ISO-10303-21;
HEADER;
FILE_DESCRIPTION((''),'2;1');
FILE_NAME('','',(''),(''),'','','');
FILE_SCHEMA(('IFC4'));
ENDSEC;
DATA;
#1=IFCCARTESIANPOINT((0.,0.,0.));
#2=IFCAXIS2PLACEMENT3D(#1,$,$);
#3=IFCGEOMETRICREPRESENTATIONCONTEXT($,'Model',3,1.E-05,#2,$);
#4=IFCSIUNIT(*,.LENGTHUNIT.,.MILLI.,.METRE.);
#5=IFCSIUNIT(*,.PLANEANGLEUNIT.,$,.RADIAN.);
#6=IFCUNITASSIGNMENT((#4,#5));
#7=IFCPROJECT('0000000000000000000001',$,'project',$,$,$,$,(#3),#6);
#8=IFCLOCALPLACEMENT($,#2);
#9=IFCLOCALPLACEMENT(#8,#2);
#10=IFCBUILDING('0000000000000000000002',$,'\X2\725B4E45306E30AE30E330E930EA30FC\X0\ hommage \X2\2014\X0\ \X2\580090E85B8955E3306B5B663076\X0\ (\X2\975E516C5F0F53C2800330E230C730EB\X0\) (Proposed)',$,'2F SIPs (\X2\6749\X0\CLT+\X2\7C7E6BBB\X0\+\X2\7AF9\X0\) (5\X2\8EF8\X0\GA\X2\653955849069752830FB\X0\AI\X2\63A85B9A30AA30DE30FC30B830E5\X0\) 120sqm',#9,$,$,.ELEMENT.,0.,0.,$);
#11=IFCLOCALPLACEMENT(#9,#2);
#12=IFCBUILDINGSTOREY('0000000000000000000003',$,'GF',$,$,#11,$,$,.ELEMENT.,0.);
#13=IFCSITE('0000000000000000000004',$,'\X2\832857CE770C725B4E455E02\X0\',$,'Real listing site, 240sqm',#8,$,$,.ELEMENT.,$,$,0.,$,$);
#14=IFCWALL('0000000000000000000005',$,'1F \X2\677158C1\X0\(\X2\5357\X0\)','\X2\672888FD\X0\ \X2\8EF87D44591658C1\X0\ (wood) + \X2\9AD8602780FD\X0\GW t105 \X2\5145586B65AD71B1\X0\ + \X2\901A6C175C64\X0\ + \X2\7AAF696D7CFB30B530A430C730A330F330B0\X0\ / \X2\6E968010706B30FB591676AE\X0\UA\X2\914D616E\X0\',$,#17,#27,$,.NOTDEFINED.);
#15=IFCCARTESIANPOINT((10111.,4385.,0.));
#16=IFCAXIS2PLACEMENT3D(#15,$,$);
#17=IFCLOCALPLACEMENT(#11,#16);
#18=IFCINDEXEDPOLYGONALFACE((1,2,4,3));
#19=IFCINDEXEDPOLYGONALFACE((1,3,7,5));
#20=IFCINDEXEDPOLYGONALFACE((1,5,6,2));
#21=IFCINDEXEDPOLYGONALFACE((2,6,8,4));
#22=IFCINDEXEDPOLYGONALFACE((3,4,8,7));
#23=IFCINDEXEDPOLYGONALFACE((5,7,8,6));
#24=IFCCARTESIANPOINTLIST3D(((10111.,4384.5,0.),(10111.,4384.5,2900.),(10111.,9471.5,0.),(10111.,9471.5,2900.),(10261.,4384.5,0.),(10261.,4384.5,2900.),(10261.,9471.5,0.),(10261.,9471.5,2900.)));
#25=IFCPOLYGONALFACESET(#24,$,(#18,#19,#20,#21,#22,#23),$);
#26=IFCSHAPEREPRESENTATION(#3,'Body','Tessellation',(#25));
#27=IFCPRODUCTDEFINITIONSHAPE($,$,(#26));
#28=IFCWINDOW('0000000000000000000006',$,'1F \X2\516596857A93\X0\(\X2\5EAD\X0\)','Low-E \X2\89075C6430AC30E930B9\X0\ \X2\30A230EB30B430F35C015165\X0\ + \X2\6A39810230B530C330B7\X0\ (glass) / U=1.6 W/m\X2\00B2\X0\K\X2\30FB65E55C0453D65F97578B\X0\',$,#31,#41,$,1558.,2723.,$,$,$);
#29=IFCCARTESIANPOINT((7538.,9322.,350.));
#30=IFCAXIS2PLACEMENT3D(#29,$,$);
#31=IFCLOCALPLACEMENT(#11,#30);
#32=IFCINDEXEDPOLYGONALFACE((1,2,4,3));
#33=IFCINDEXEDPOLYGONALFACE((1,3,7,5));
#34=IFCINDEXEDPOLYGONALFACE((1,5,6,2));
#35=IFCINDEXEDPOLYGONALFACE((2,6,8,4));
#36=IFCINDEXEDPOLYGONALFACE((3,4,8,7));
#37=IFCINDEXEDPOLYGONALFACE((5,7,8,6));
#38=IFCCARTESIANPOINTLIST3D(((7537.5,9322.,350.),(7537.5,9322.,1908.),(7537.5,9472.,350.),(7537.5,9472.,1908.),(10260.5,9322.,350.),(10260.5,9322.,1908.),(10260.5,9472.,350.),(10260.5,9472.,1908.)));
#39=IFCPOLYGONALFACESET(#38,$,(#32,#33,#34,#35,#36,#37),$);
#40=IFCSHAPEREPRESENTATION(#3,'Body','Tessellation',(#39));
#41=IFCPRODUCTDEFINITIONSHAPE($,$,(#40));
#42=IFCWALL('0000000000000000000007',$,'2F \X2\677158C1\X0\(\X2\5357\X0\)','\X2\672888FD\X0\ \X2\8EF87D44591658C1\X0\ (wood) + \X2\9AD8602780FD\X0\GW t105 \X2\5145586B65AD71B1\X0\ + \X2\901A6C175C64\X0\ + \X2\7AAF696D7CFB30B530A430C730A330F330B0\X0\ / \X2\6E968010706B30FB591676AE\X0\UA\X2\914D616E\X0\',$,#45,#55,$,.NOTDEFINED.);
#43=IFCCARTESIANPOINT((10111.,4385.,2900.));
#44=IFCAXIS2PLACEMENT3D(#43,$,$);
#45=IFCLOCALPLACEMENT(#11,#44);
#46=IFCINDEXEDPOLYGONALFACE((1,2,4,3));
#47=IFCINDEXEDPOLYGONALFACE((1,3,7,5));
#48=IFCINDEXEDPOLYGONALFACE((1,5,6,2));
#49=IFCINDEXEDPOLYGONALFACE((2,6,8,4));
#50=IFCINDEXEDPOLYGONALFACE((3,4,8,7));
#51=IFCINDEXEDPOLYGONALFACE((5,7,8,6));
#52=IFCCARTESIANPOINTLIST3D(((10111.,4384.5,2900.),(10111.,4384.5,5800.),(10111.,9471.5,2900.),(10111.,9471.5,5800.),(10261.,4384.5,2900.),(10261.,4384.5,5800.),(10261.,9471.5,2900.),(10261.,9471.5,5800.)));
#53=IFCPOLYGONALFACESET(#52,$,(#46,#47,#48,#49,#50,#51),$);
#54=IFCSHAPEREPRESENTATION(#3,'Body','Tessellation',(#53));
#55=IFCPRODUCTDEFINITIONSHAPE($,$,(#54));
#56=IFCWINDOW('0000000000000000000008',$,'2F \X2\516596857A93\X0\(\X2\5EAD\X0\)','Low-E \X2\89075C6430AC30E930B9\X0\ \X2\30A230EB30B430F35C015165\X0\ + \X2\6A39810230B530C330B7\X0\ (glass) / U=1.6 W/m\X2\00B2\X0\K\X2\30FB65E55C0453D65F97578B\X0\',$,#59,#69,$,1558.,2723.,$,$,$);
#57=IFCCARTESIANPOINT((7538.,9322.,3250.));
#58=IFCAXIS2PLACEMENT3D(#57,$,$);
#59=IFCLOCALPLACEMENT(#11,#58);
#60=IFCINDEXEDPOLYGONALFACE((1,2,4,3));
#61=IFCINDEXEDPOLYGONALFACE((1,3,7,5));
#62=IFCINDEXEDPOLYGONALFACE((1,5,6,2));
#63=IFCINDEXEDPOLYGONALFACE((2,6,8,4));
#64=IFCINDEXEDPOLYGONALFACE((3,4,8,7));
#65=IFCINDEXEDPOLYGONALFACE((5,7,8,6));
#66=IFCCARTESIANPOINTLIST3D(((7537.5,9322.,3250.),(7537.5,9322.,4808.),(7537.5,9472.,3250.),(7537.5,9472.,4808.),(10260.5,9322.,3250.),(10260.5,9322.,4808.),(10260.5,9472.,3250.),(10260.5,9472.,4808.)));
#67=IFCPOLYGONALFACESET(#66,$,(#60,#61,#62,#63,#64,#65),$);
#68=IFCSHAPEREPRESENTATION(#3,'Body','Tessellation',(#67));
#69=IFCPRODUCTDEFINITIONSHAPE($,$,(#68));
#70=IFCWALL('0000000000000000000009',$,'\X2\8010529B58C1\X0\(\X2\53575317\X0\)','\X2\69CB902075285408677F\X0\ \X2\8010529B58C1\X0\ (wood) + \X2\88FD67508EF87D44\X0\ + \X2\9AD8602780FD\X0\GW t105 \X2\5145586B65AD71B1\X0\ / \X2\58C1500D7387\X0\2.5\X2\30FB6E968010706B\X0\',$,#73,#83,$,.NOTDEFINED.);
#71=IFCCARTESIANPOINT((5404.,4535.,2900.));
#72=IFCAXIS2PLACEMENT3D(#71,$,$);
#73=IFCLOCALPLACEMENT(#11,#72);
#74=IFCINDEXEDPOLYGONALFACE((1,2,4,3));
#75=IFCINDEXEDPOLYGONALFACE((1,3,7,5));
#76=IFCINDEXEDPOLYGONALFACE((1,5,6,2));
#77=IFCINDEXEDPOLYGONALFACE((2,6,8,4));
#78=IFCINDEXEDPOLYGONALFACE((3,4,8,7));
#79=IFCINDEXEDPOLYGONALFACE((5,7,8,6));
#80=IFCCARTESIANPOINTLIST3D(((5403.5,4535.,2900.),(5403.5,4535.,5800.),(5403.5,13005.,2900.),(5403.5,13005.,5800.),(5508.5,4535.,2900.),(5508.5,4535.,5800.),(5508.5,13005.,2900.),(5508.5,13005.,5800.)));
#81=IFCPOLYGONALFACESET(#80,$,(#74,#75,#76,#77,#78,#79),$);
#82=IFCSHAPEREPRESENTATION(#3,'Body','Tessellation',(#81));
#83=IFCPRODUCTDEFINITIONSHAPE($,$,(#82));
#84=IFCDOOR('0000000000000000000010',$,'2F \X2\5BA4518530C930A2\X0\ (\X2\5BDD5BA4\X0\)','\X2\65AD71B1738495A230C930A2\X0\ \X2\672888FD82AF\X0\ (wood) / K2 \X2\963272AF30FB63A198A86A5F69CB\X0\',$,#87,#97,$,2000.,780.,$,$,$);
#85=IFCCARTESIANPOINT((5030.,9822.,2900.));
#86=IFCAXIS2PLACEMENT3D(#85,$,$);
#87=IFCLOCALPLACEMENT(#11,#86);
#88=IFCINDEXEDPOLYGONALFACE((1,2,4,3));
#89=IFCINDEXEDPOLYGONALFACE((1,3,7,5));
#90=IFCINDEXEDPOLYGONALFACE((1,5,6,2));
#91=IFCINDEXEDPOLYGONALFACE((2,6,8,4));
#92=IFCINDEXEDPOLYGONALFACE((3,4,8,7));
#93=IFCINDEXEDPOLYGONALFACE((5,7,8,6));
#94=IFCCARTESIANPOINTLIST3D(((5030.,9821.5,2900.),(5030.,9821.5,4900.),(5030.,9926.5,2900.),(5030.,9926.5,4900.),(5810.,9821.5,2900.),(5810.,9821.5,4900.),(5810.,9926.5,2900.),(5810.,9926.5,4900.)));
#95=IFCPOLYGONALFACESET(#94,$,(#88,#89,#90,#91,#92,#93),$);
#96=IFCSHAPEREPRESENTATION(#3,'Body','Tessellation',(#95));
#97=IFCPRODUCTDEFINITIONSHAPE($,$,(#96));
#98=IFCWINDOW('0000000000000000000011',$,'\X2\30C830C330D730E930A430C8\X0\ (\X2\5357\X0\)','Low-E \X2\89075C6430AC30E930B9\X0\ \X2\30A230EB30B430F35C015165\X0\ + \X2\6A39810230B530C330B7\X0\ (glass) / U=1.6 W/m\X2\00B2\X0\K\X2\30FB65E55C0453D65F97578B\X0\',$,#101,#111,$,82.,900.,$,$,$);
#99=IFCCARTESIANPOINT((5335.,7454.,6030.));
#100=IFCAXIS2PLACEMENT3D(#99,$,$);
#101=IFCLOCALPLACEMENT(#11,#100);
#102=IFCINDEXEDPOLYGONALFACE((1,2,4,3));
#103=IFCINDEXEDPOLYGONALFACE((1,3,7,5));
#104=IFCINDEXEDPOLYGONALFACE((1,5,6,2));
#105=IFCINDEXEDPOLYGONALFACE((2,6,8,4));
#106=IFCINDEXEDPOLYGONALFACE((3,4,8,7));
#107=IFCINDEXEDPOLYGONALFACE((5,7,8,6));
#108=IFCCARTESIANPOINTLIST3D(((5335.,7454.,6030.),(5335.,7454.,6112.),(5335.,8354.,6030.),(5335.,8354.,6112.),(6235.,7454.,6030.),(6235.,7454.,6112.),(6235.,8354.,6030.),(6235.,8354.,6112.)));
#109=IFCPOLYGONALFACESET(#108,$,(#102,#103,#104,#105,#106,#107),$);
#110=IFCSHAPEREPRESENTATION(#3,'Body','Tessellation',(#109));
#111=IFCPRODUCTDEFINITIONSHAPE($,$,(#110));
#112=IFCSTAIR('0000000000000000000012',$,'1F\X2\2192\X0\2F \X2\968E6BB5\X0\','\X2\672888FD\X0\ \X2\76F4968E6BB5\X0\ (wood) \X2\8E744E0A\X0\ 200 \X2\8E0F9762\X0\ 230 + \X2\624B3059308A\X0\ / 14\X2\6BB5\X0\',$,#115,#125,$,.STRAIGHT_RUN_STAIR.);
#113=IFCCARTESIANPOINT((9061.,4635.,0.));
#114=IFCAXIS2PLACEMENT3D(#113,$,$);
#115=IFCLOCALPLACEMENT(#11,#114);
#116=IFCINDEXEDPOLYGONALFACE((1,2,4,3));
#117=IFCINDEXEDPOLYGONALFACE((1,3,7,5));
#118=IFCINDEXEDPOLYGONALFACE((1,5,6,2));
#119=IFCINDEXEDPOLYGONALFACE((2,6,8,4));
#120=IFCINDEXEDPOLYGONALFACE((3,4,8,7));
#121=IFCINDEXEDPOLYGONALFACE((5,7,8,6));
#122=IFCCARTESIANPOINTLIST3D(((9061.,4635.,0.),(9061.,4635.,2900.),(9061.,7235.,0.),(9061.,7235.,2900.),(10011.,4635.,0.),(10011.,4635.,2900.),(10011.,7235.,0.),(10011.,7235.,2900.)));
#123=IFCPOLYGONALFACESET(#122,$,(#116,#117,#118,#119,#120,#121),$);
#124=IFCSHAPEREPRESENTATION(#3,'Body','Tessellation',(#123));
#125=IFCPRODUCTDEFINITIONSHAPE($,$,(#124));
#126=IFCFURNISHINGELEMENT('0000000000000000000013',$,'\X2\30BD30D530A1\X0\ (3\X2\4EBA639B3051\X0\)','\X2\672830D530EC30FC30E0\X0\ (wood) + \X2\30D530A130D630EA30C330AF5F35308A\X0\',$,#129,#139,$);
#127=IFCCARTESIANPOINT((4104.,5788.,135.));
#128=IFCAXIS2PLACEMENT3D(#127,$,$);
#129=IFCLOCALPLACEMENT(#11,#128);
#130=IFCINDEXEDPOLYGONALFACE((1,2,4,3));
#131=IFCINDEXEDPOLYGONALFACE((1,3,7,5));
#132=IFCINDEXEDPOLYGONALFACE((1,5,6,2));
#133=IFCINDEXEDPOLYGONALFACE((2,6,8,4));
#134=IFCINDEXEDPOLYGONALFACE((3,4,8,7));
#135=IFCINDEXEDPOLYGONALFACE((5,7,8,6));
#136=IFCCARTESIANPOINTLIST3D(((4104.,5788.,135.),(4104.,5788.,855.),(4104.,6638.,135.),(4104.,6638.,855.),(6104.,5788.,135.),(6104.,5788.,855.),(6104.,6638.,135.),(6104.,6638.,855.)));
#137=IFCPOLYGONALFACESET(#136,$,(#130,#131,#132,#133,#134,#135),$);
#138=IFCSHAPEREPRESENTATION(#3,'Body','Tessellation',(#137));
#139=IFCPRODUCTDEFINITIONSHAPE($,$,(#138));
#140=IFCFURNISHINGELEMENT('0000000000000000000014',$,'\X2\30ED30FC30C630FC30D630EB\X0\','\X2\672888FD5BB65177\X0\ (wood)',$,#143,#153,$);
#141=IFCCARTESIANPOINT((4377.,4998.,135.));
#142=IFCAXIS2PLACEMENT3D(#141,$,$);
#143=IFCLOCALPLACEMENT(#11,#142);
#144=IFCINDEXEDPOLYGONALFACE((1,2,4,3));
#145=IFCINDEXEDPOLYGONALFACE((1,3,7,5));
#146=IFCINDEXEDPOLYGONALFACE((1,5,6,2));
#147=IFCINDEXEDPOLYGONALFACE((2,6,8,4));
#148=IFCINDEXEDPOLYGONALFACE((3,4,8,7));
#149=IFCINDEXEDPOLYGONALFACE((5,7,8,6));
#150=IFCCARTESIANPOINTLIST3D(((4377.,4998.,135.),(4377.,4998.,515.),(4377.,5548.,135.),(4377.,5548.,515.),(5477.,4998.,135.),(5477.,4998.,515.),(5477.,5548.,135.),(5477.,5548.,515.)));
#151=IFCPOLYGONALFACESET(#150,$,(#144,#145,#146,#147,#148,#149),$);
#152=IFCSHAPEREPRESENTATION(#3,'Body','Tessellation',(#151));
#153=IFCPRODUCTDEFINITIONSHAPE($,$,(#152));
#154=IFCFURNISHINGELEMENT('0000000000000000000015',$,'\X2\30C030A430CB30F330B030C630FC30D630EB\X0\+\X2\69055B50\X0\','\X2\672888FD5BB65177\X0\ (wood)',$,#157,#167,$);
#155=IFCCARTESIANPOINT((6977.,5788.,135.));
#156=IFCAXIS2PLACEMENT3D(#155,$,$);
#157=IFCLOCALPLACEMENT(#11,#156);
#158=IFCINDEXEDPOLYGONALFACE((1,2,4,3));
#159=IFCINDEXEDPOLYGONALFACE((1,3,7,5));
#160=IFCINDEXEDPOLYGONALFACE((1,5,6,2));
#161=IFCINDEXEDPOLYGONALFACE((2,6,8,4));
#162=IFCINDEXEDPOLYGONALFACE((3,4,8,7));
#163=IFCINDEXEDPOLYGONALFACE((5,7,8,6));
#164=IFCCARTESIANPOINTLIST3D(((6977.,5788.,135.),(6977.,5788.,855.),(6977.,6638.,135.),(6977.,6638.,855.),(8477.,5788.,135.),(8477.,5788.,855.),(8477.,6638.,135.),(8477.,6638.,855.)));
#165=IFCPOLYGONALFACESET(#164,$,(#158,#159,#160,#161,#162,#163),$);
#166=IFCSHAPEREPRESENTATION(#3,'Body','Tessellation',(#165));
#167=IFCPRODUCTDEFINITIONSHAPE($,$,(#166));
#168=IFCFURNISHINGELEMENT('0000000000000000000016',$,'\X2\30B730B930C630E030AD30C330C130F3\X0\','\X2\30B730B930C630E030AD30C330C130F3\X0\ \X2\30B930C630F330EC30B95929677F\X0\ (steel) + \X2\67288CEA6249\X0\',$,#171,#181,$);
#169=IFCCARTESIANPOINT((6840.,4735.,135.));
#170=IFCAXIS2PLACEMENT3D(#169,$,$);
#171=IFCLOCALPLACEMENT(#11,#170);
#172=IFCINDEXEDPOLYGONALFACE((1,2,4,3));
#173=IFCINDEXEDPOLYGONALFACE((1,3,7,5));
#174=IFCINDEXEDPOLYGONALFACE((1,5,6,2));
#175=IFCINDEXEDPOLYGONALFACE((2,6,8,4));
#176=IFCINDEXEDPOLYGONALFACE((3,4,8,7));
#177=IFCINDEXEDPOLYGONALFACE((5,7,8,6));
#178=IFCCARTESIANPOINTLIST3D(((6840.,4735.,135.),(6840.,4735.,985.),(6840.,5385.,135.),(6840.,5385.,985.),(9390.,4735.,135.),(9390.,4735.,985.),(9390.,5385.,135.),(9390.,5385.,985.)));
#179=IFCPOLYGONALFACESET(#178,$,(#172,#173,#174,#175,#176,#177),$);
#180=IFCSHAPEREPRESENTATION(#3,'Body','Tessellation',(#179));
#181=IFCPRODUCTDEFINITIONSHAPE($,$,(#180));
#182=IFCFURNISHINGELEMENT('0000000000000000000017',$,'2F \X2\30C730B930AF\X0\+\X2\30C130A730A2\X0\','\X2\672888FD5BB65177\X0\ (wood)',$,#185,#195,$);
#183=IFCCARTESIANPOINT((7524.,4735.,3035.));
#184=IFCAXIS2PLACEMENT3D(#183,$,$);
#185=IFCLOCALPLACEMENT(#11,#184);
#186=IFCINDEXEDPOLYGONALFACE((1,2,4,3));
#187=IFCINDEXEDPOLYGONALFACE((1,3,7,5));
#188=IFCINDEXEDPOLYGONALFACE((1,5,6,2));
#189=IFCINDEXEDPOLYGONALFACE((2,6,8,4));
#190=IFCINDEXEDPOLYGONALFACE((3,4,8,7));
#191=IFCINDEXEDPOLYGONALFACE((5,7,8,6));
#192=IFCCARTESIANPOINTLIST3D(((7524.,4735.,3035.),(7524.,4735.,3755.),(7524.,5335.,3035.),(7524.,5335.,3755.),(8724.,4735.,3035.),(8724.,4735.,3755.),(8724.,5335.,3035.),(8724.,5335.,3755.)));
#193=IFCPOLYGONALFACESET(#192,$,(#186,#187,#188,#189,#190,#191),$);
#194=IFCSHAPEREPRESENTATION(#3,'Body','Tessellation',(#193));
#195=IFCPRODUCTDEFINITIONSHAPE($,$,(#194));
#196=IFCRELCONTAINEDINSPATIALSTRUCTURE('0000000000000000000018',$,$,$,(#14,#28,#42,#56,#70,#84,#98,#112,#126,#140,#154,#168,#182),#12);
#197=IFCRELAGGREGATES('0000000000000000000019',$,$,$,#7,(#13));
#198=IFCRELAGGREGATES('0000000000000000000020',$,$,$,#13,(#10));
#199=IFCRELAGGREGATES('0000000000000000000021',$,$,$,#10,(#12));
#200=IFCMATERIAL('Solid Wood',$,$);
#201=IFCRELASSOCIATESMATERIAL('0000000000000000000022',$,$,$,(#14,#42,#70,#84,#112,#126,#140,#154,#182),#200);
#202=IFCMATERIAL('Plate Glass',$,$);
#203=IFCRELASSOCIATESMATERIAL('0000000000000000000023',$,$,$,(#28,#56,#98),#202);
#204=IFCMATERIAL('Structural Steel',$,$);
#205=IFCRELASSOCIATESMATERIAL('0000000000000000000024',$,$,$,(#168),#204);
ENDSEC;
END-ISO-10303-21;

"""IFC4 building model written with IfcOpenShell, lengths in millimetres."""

from ifc_helpers import new_model, si_unit, frame, frame_2d, origin, place, context, project, spatial, rectangle, extrude, material, element, fill, save


model = new_model("IFC4")

# Units and contexts
model_context = context("Model", 3, precision=1e-05, world=origin())
ifc_project = project(units=[si_unit("LENGTHUNIT", "METRE", prefix="MILLI"), si_unit("PLANEANGLEUNIT", "RADIAN")], contexts=[model_context])

# Site, building, storey
site_placement = place(None, origin())
site = spatial("IfcSite", under=ifc_project, at=site_placement, Name="茨城県牛久市", ObjectType="Real listing site, 240sqm", CompositionType="ELEMENT", RefElevation=0.0)
building_placement = place(site_placement, origin())
building = spatial("IfcBuilding", under=site, at=building_placement, Name="牛久のギャラリー hommage — 堀部安嗣に学ぶ (非公式参考モデル) (Proposed)", ObjectType="2F SIPs (杉CLT+籾殻+竹) (5軸GA改善適用・AI推定オマージュ) 120sqm", CompositionType="ELEMENT", ElevationOfRefHeight=0.0, ElevationOfTerrain=0.0)
storey_placement = place(building_placement, origin())
storey = spatial("IfcBuildingStorey", under=building, at=storey_placement, Name="GF", CompositionType="ELEMENT", Elevation=0.0)

# Wall, opening, window
ifc_material_1 = material(Name="Solid Wood")
wall_1_placement = place(storey_placement, frame((10111.0, 4385.0, 0.0)))
wall_1 = element("IfcWall", 1, at=wall_1_placement, inside=storey, material=ifc_material_1, Name="1F 東壁(南)", Description="木製 軸組外壁 (wood) + 高性能GW t105 充填断熱 + 通気層 + 窯業系サイディング / 準耐火・外皮UA配慮", PredefinedType="NOTDEFINED", context=model_context, shape_type="SweptSolid", body=[
    extrude(rectangle(XDim=150.0, YDim=5087.0, at=frame_2d((75.0, 2543.0))), frame((10111.0, 4385.0, 0.0)), (0.0, 0.0, 1.0), 2900.0),
])
opening_1_placement = place(storey_placement, frame((7538.0, 9322.0, 350.0)))
opening_1 = element("IfcOpeningElement", 2, at=opening_1_placement, cuts=wall_1, PredefinedType="NOTDEFINED", context=model_context, shape_type="SweptSolid", body=[
    extrude(rectangle(XDim=2723.0, YDim=150.0, at=frame_2d((1361.0, 75.0))), frame((7538.0, 9322.0, 350.0)), (0.0, 0.0, 1.0), 1558.0),
])
ifc_material_2 = material(Name="Plate Glass")
window_1_placement = place(storey_placement, frame((7538.0, 9322.0, 350.0)))
window_1 = element("IfcWindow", 3, at=window_1_placement, inside=storey, material=ifc_material_2, Name="1F 入隅窓(庭)", Description="Low-E 複層ガラス アルゴン封入 + 樹脂サッシ (glass) / U=1.6 W/m²K・日射取得型", OverallHeight=1558.0, OverallWidth=2723.0, context=model_context, shape_type="SweptSolid", body=[
    extrude(rectangle(XDim=2723.0, YDim=150.0, at=frame_2d((1361.0, 75.0))), frame((7538.0, 9322.0, 350.0)), (0.0, 0.0, 1.0), 1558.0),
])
fill(opening_1, window_1)

# Wall, opening, window
wall_2_placement = place(storey_placement, frame((10111.0, 4385.0, 2900.0)))
wall_2 = element("IfcWall", 4, at=wall_2_placement, inside=storey, material=ifc_material_1, Name="2F 東壁(南)", Description="木製 軸組外壁 (wood) + 高性能GW t105 充填断熱 + 通気層 + 窯業系サイディング / 準耐火・外皮UA配慮", PredefinedType="NOTDEFINED", context=model_context, shape_type="SweptSolid", body=[
    extrude(rectangle(XDim=150.0, YDim=5087.0, at=frame_2d((75.0, 2543.0))), frame((10111.0, 4385.0, 2900.0)), (0.0, 0.0, 1.0), 2900.0),
])
opening_2_placement = place(storey_placement, frame((7538.0, 9322.0, 3250.0)))
opening_2 = element("IfcOpeningElement", 5, at=opening_2_placement, cuts=wall_2, PredefinedType="NOTDEFINED", context=model_context, shape_type="SweptSolid", body=[
    extrude(rectangle(XDim=2723.0, YDim=150.0, at=frame_2d((1361.0, 75.0))), frame((7538.0, 9322.0, 3250.0)), (0.0, 0.0, 1.0), 1558.0),
])
window_2_placement = place(storey_placement, frame((7538.0, 9322.0, 3250.0)))
window_2 = element("IfcWindow", 6, at=window_2_placement, inside=storey, material=ifc_material_2, Name="2F 入隅窓(庭)", Description="Low-E 複層ガラス アルゴン封入 + 樹脂サッシ (glass) / U=1.6 W/m²K・日射取得型", OverallHeight=1558.0, OverallWidth=2723.0, context=model_context, shape_type="SweptSolid", body=[
    extrude(rectangle(XDim=2723.0, YDim=150.0, at=frame_2d((1361.0, 75.0))), frame((7538.0, 9322.0, 3250.0)), (0.0, 0.0, 1.0), 1558.0),
])
fill(opening_2, window_2)

# Wall, opening, door
wall_3_placement = place(storey_placement, frame((5404.0, 4535.0, 2900.0)))
wall_3 = element("IfcWall", 7, at=wall_3_placement, inside=storey, material=ifc_material_1, Name="耐力壁(南北)", Description="構造用合板 耐力壁 (wood) + 製材軸組 + 高性能GW t105 充填断熱 / 壁倍率2.5・準耐火", PredefinedType="NOTDEFINED", context=model_context, shape_type="SweptSolid", body=[
    extrude(rectangle(XDim=105.0, YDim=8470.0, at=frame_2d((52.0, 4235.0))), frame((5404.0, 4535.0, 2900.0)), (0.0, 0.0, 1.0), 2900.0),
])
opening_3_placement = place(storey_placement, frame((5030.0, 9822.0, 2900.0)))
opening_3 = element("IfcOpeningElement", 8, at=opening_3_placement, cuts=wall_3, PredefinedType="NOTDEFINED", context=model_context, shape_type="SweptSolid", body=[
    extrude(rectangle(XDim=780.0, YDim=105.0, at=frame_2d((390.0, 52.0))), frame((5030.0, 9822.0, 2900.0)), (0.0, 0.0, 1.0), 2000.0),
])
door_1_placement = place(storey_placement, frame((5030.0, 9822.0, 2900.0)))
door_1 = element("IfcDoor", 9, at=door_1_placement, inside=storey, material=ifc_material_1, Name="2F 室内ドア (寝室)", Description="断熱玄関ドア 木製芯 (wood) / K2 防犯・採風機構", OverallHeight=2000.0, OverallWidth=780.0, context=model_context, shape_type="SweptSolid", body=[
    extrude(rectangle(XDim=780.0, YDim=105.0, at=frame_2d((390.0, 52.0))), frame((5030.0, 9822.0, 2900.0)), (0.0, 0.0, 1.0), 2000.0),
])
fill(opening_3, door_1)

# Window
window_3_placement = place(storey_placement, frame((5335.0, 7454.0, 6030.0)))
element("IfcWindow", 10, at=window_3_placement, inside=storey, material=ifc_material_2, Name="トップライト (南)", Description="Low-E 複層ガラス アルゴン封入 + 樹脂サッシ (glass) / U=1.6 W/m²K・日射取得型", OverallHeight=82.0, OverallWidth=900.0, context=model_context, shape_type="SweptSolid", body=[
    extrude(rectangle(XDim=900.0, YDim=900.0, at=frame_2d((450.0, 450.0))), frame((5335.0, 7454.0, 6030.0)), (0.0, 0.0, 1.0), 82.0),
])

# Stair
stair_placement = place(storey_placement, frame((9061.0, 4635.0, 0.0)))
element("IfcStair", 11, at=stair_placement, inside=storey, material=ifc_material_1, Name="1F→2F 階段", Description="木製 直階段 (wood) 蹴上 200 踏面 230 + 手すり / 14段", PredefinedType="STRAIGHT_RUN_STAIR", context=model_context, shape_type="SweptSolid", body=[
    extrude(rectangle(XDim=950.0, YDim=2600.0, at=frame_2d((475.0, 1300.0))), frame((9061.0, 4635.0, 0.0)), (0.0, 0.0, 1.0), 2900.0),
])

# Furnishing elements
furnishing_1_placement = place(storey_placement, frame((4104.0, 5788.0, 135.0)))
element("IfcFurnishingElement", 12, at=furnishing_1_placement, inside=storey, material=ifc_material_1, Name="ソファ (3人掛け)", Description="木フレーム (wood) + ファブリック張り", context=model_context, shape_type="SweptSolid", body=[
    extrude(rectangle(XDim=2000.0, YDim=850.0, at=frame_2d((1000.0, 425.0))), frame((4104.0, 5788.0, 135.0)), (0.0, 0.0, 1.0), 720.0),
])
furnishing_2_placement = place(storey_placement, frame((4377.0, 4998.0, 135.0)))
element("IfcFurnishingElement", 13, at=furnishing_2_placement, inside=storey, material=ifc_material_1, Name="ローテーブル", Description="木製家具 (wood)", context=model_context, shape_type="SweptSolid", body=[
    extrude(rectangle(XDim=1100.0, YDim=550.0, at=frame_2d((550.0, 275.0))), frame((4377.0, 4998.0, 135.0)), (0.0, 0.0, 1.0), 380.0),
])
furnishing_3_placement = place(storey_placement, frame((6977.0, 5788.0, 135.0)))
element("IfcFurnishingElement", 14, at=furnishing_3_placement, inside=storey, material=ifc_material_1, Name="ダイニングテーブル+椅子", Description="木製家具 (wood)", context=model_context, shape_type="SweptSolid", body=[
    extrude(rectangle(XDim=1500.0, YDim=850.0, at=frame_2d((750.0, 425.0))), frame((6977.0, 5788.0, 135.0)), (0.0, 0.0, 1.0), 720.0),
])
ifc_material_3 = material(Name="Structural Steel")
furnishing_4_placement = place(storey_placement, frame((6840.0, 4735.0, 135.0)))
element("IfcFurnishingElement", 15, at=furnishing_4_placement, inside=storey, material=ifc_material_3, Name="システムキッチン", Description="システムキッチン ステンレス天板 (steel) + 木質扉", context=model_context, shape_type="SweptSolid", body=[
    extrude(rectangle(XDim=2550.0, YDim=650.0, at=frame_2d((1275.0, 325.0))), frame((6840.0, 4735.0, 135.0)), (0.0, 0.0, 1.0), 850.0),
])
furnishing_5_placement = place(storey_placement, frame((7524.0, 4735.0, 3035.0)))
element("IfcFurnishingElement", 16, at=furnishing_5_placement, inside=storey, material=ifc_material_1, Name="2F デスク+チェア", Description="木製家具 (wood)", context=model_context, shape_type="SweptSolid", body=[
    extrude(rectangle(XDim=1200.0, YDim=600.0, at=frame_2d((600.0, 300.0))), frame((7524.0, 4735.0, 3035.0)), (0.0, 0.0, 1.0), 720.0),
])

save(model, "model.ifc")
